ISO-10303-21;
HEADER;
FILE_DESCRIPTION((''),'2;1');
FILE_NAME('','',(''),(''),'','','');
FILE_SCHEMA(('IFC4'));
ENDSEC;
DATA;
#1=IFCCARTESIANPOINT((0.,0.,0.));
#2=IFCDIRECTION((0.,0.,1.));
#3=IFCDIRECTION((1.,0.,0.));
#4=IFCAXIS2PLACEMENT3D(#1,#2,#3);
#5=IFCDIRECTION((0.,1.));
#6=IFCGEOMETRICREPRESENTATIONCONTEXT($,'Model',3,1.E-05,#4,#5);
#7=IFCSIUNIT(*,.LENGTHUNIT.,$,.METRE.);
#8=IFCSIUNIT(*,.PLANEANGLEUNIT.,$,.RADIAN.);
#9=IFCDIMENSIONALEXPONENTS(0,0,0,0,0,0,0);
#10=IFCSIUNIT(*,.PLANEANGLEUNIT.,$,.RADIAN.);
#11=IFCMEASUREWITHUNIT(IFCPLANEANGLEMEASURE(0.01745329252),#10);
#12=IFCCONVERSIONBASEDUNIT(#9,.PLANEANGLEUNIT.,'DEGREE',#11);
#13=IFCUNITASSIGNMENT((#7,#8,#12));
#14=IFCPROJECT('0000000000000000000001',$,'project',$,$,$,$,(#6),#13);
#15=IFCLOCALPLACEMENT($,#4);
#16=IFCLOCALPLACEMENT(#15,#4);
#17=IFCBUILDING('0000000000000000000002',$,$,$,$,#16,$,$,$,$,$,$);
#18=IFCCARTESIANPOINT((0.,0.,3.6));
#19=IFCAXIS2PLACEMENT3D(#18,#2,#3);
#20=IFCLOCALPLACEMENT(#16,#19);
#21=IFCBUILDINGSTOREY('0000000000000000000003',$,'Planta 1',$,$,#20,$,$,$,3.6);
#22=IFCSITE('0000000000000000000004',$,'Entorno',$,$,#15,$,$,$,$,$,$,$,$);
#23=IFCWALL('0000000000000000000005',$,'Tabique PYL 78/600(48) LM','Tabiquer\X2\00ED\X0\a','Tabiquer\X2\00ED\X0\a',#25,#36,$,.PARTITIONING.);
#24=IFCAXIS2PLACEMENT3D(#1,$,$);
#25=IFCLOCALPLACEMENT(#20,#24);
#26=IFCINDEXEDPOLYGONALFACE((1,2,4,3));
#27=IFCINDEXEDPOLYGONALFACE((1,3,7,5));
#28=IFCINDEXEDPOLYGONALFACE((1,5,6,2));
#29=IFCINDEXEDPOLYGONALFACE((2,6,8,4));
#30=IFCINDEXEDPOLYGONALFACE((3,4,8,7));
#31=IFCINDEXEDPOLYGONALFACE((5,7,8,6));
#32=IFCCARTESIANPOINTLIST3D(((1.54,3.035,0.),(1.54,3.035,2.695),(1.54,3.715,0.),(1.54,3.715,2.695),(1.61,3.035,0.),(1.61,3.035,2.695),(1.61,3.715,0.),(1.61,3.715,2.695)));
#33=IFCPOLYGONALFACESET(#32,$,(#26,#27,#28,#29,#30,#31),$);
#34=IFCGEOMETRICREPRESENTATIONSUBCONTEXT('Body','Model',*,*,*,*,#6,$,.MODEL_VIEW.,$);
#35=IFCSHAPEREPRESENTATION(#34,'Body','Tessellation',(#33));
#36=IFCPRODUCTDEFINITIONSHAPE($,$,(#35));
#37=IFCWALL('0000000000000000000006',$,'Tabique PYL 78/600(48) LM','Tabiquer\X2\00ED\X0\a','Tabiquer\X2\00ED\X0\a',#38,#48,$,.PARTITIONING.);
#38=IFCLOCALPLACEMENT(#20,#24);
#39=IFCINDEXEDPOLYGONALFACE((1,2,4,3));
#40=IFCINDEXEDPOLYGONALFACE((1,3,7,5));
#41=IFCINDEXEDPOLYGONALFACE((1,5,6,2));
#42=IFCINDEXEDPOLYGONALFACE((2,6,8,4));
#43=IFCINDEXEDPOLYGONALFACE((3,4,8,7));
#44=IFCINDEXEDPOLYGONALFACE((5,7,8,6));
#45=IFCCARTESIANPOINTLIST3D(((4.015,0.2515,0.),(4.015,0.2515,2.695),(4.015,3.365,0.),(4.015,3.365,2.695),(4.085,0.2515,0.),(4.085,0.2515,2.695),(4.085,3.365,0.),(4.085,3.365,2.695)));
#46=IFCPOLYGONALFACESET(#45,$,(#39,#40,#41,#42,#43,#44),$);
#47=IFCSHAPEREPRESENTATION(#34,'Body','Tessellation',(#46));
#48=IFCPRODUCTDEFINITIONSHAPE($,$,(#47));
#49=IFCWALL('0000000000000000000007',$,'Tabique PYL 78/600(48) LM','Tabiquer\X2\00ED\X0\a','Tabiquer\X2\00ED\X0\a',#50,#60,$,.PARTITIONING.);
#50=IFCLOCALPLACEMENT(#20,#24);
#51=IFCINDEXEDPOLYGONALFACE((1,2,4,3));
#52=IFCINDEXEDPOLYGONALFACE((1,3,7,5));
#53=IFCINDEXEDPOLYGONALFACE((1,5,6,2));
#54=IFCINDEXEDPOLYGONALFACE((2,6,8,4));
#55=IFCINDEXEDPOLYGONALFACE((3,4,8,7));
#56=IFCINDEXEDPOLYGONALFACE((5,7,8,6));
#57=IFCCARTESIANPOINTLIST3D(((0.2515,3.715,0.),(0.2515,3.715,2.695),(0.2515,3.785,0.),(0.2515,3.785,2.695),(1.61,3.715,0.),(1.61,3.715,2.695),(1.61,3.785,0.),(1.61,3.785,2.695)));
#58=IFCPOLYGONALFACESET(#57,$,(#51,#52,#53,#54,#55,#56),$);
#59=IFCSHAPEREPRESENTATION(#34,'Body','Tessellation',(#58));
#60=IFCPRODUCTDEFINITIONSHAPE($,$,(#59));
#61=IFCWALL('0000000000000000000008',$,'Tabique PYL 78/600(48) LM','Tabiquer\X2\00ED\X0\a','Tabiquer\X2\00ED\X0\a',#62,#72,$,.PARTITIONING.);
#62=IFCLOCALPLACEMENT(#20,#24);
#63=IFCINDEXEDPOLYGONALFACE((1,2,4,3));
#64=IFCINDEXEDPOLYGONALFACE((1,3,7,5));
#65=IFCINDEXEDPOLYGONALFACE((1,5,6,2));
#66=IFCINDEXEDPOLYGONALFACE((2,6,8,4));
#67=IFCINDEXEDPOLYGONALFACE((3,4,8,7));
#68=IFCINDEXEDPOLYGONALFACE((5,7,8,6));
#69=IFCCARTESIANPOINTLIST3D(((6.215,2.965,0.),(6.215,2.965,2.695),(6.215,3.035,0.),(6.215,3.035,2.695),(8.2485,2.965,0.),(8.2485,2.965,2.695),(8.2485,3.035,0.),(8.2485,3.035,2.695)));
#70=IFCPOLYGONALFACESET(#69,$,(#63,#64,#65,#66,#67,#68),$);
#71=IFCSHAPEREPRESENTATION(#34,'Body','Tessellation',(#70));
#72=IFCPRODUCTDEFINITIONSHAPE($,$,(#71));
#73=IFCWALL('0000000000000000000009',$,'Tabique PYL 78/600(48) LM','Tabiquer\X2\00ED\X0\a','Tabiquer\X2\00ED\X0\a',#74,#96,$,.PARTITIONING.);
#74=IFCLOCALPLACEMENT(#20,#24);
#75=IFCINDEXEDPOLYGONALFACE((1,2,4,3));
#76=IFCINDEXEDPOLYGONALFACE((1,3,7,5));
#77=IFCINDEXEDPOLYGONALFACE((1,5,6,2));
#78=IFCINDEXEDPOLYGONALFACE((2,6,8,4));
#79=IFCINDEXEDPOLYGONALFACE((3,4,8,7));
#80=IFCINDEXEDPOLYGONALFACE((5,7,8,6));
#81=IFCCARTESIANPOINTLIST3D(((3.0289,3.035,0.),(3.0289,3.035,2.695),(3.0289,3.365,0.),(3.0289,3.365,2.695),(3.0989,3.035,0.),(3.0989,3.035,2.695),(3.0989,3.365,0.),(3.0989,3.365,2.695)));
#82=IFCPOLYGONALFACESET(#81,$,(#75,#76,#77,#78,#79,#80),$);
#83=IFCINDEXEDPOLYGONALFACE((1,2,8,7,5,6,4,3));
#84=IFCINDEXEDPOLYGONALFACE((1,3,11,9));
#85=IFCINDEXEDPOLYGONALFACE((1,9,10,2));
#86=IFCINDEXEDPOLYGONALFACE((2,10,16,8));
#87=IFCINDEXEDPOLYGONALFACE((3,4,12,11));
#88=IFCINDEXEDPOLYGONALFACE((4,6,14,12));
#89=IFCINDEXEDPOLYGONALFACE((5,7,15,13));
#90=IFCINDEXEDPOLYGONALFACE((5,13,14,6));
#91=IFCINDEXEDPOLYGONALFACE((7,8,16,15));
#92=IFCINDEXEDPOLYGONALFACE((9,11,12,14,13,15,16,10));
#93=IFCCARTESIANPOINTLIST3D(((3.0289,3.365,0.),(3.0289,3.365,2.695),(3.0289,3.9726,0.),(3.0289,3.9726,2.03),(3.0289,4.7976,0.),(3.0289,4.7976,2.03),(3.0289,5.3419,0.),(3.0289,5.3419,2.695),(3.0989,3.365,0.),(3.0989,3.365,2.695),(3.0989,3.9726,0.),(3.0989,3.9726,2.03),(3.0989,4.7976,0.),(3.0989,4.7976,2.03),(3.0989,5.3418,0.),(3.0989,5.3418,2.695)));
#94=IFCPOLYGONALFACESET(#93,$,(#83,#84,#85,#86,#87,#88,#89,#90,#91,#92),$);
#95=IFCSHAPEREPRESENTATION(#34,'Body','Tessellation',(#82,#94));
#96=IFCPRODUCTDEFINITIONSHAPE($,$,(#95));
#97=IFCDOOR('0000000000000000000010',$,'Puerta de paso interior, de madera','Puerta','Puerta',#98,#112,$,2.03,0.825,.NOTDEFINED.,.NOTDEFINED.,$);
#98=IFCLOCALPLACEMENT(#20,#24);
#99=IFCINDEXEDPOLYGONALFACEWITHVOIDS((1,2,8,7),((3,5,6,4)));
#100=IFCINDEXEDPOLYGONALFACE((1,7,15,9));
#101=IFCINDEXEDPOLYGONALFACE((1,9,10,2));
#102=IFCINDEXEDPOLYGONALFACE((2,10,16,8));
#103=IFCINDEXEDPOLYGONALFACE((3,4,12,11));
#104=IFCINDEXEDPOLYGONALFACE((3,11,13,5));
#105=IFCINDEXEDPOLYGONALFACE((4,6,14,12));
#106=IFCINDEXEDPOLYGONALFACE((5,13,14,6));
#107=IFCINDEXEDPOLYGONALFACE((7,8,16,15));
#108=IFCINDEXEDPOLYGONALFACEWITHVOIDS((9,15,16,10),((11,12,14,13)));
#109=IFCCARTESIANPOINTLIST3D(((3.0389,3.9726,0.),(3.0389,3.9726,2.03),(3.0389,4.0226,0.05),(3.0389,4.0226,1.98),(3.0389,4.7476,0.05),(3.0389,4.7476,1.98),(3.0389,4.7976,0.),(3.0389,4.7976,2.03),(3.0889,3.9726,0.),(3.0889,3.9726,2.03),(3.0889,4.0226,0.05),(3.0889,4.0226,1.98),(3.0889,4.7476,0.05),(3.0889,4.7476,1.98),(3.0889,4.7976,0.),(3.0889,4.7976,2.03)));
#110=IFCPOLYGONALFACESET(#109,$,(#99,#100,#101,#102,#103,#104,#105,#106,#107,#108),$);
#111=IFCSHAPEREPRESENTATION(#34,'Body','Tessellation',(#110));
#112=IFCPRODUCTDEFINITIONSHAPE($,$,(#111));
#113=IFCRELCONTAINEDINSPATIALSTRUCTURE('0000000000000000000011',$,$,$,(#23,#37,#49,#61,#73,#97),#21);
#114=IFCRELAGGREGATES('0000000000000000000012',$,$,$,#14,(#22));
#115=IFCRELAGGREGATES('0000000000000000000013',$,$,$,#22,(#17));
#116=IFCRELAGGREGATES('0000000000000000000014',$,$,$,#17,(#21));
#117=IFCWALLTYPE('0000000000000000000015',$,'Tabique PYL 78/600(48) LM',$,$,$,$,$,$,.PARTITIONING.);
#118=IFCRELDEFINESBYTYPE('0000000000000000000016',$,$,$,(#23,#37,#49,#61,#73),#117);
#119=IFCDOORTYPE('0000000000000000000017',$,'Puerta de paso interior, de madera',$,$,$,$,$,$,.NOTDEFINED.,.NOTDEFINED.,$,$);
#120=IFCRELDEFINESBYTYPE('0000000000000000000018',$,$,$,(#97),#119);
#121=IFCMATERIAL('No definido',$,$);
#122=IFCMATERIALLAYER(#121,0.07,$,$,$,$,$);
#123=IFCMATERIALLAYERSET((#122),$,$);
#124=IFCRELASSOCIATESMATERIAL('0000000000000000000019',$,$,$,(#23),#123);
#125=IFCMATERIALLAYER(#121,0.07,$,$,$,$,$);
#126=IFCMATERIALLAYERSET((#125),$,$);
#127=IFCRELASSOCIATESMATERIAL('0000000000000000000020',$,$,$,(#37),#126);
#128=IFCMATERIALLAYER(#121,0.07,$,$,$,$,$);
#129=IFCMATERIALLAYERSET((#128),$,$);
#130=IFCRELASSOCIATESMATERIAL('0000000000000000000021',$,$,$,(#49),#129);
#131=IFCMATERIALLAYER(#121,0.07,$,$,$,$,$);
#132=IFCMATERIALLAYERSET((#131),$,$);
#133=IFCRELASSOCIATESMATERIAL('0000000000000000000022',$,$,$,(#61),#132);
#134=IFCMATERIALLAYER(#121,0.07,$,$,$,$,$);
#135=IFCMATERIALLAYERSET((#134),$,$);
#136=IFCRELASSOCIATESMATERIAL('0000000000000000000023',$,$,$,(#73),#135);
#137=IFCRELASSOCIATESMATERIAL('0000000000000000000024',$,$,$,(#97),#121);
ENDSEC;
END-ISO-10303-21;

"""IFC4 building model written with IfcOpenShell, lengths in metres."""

from ifc_helpers import new_model, entity, si_unit, converted_unit, direction, frame, origin_with_axes, origin_2d_with_axis, place, context, subcontext, project, spatial, rectangle, hollow_rectangle, extrude, shape, material, layer, layer_set, layer_usage, type_object, element, fill, save


model = new_model("IFC4")

# Units and contexts
model_context = context("Model", 3, precision=1e-05, world=origin_with_axes(), true_north=direction((0.0, 1.0)))
body_context = subcontext(model_context, "Body", "Model", "MODEL_VIEW")
footprint_context = subcontext(model_context, "FootPrint", "Model", "MODEL_VIEW")
ifc_project = project(units=[si_unit("LENGTHUNIT", "METRE"), si_unit("PLANEANGLEUNIT", "RADIAN"), converted_unit("PLANEANGLEUNIT", "DEGREE", entity("IfcPlaneAngleMeasure", 0.01745329252), si_unit("PLANEANGLEUNIT", "RADIAN"), dimensions=[0, 0, 0, 0, 0, 0, 0])], contexts=[model_context])

# Site, building, storey
site_placement = place(None, origin_with_axes())
site = spatial("IfcSite", under=ifc_project, at=site_placement, Name="Entorno")
building_placement = place(site_placement, origin_with_axes())
building = spatial("IfcBuilding", under=site, at=building_placement)
storey_placement = place(building_placement, frame((0.0, 0.0, 3.6), z_axis=(0.0, 0.0, 1.0), x_axis=(1.0, 0.0, 0.0)))
storey = spatial("IfcBuildingStorey", under=building, at=storey_placement, Name="Planta 1", Elevation=3.6)

# Shared definitions
ifc_material = material(Name="No definido")

# Shared definitions
wall_type_1 = type_object("IfcWallType", Name="Tabique PYL 78/600(48) LM", PredefinedType="PARTITIONING")
door_type = type_object("IfcDoorType", Name="Puerta de paso interior, de madera", OperationType="NOTDEFINED", PredefinedType="NOTDEFINED")

# Walls
ifc_layer_1 = layer(ifc_material, 0.07)
ifc_layer_set_1 = layer_set([ifc_layer_1])
ifc_layer_usage_1 = layer_usage(ifc_layer_set_1, "AXIS2", "POSITIVE", -0.035)
wall_1_placement = place(storey_placement, frame((1.575, 3.75, 0.0), z_axis=(0.0, 0.0, 1.0), x_axis=(0.0, -1.0, 0.0)))
cartesian_point_1 = entity("IfcCartesianPoint", [-0.34, -1.3475])
cartesian_point_2 = entity("IfcCartesianPoint", [-0.34, -1.3475])
element("IfcWall", 1, at=wall_1_placement, inside=storey, type_object=wall_type_1, material=ifc_layer_usage_1, Name="Tabique PYL 78/600(48) LM", Description="Tabiquería", ObjectType="Tabiquería", PredefinedType="PARTITIONING", context=body_context, shape_type="SolidModel", body=[
    entity("IfcExtrudedAreaSolidTapered", entity("IfcArbitraryClosedProfileDef", "AREA", None, entity("IfcPolyline", [cartesian_point_1, entity("IfcCartesianPoint", [0.34, -1.3475]), entity("IfcCartesianPoint", [0.34, 1.3475]), entity("IfcCartesianPoint", [-0.34, 1.3475]), cartesian_point_1])), entity("IfcAxis2Placement3D", entity("IfcCartesianPoint", [0.375, 0.035, 1.3475]), entity("IfcDirection", [0.0, -1.0, 0.0]), entity("IfcDirection", [1.0, 0.0, 0.0])), entity("IfcDirection", [0.0, 0.0, 1.0]), 0.07, entity("IfcArbitraryClosedProfileDef", "AREA", None, entity("IfcPolyline", [cartesian_point_2, entity("IfcCartesianPoint", [0.34, -1.3475]), entity("IfcCartesianPoint", [0.34, 1.3475]), entity("IfcCartesianPoint", [-0.34, 1.3475]), cartesian_point_2]))),
])
ifc_layer_2 = layer(ifc_material, 0.07)
ifc_layer_set_2 = layer_set([ifc_layer_2])
ifc_layer_usage_2 = layer_usage(ifc_layer_set_2, "AXIS2", "POSITIVE", -0.035)
wall_2_placement = place(storey_placement, frame((4.05, 3.4, 0.0), z_axis=(0.0, 0.0, 1.0), x_axis=(0.0, -1.0, 0.0)))
cartesian_point_3 = entity("IfcCartesianPoint", [-1.5568, -1.3475])
cartesian_point_4 = entity("IfcCartesianPoint", [-1.5568, -1.3475])
element("IfcWall", 2, at=wall_2_placement, inside=storey, type_object=wall_type_1, material=ifc_layer_usage_2, Name="Tabique PYL 78/600(48) LM", Description="Tabiquería", ObjectType="Tabiquería", PredefinedType="PARTITIONING", context=body_context, shape_type="SolidModel", body=[
    entity("IfcExtrudedAreaSolidTapered", entity("IfcArbitraryClosedProfileDef", "AREA", None, entity("IfcPolyline", [cartesian_point_3, entity("IfcCartesianPoint", [1.5568, -1.3475]), entity("IfcCartesianPoint", [1.5568, 1.3475]), entity("IfcCartesianPoint", [-1.5568, 1.3475]), cartesian_point_3])), entity("IfcAxis2Placement3D", entity("IfcCartesianPoint", [1.5917, 0.035, 1.3475]), entity("IfcDirection", [0.0, -1.0, 0.0]), entity("IfcDirection", [1.0, 0.0, 0.0])), entity("IfcDirection", [0.0, 0.0, 1.0]), 0.07, entity("IfcArbitraryClosedProfileDef", "AREA", None, entity("IfcPolyline", [cartesian_point_4, entity("IfcCartesianPoint", [1.5568, -1.3475]), entity("IfcCartesianPoint", [1.5568, 1.3475]), entity("IfcCartesianPoint", [-1.5568, 1.3475]), cartesian_point_4]))),
])
ifc_layer_3 = layer(ifc_material, 0.07)
ifc_layer_set_3 = layer_set([ifc_layer_3])
ifc_layer_usage_3 = layer_usage(ifc_layer_set_3, "AXIS2", "POSITIVE", -0.035)
wall_3_placement = place(storey_placement, frame((1.575, 3.75, 0.0), z_axis=(0.0, 0.0, 1.0), x_axis=(-1.0, 0.0, 0.0)))
cartesian_point_5 = entity("IfcCartesianPoint", [-0.6793, -1.3475])
cartesian_point_6 = entity("IfcCartesianPoint", [-0.6793, -1.3475])
element("IfcWall", 3, at=wall_3_placement, inside=storey, type_object=wall_type_1, material=ifc_layer_usage_3, Name="Tabique PYL 78/600(48) LM", Description="Tabiquería", ObjectType="Tabiquería", PredefinedType="PARTITIONING", context=body_context, shape_type="SolidModel", body=[
    entity("IfcExtrudedAreaSolidTapered", entity("IfcArbitraryClosedProfileDef", "AREA", None, entity("IfcPolyline", [cartesian_point_5, entity("IfcCartesianPoint", [0.6793, -1.3475]), entity("IfcCartesianPoint", [0.6793, 1.3475]), entity("IfcCartesianPoint", [-0.6793, 1.3475]), cartesian_point_5])), entity("IfcAxis2Placement3D", entity("IfcCartesianPoint", [0.6442, 0.035, 1.3475]), entity("IfcDirection", [0.0, -1.0, 0.0]), entity("IfcDirection", [1.0, 0.0, 0.0])), entity("IfcDirection", [0.0, 0.0, 1.0]), 0.07, entity("IfcArbitraryClosedProfileDef", "AREA", None, entity("IfcPolyline", [cartesian_point_6, entity("IfcCartesianPoint", [0.6793, -1.3475]), entity("IfcCartesianPoint", [0.6793, 1.3475]), entity("IfcCartesianPoint", [-0.6793, 1.3475]), cartesian_point_6]))),
])
ifc_layer_4 = layer(ifc_material, 0.07)
ifc_layer_set_4 = layer_set([ifc_layer_4])
ifc_layer_usage_4 = layer_usage(ifc_layer_set_4, "AXIS2", "POSITIVE", -0.035)
wall_4_placement = place(storey_placement, frame((6.25, 3.0, 0.0), z_axis=(0.0, 0.0, 1.0), x_axis=(1.0, 0.0, 0.0)))
cartesian_point_7 = entity("IfcCartesianPoint", [-1.0168, -1.3475])
cartesian_point_8 = entity("IfcCartesianPoint", [-1.0168, -1.3475])
element("IfcWall", 4, at=wall_4_placement, inside=storey, type_object=wall_type_1, material=ifc_layer_usage_4, Name="Tabique PYL 78/600(48) LM", Description="Tabiquería", ObjectType="Tabiquería", PredefinedType="PARTITIONING", context=body_context, shape_type="SolidModel", body=[
    entity("IfcExtrudedAreaSolidTapered", entity("IfcArbitraryClosedProfileDef", "AREA", None, entity("IfcPolyline", [cartesian_point_7, entity("IfcCartesianPoint", [1.0168, -1.3475]), entity("IfcCartesianPoint", [1.0168, 1.3475]), entity("IfcCartesianPoint", [-1.0168, 1.3475]), cartesian_point_7])), entity("IfcAxis2Placement3D", entity("IfcCartesianPoint", [0.9818, 0.035, 1.3475]), entity("IfcDirection", [0.0, -1.0, 0.0]), entity("IfcDirection", [1.0, 0.0, 0.0])), entity("IfcDirection", [0.0, 0.0, 1.0]), 0.07, entity("IfcArbitraryClosedProfileDef", "AREA", None, entity("IfcPolyline", [cartesian_point_8, entity("IfcCartesianPoint", [1.0168, -1.3475]), entity("IfcCartesianPoint", [1.0168, 1.3475]), entity("IfcCartesianPoint", [-1.0168, 1.3475]), cartesian_point_8]))),
])

# Wall, opening, door
ifc_layer_5 = layer(ifc_material, 0.07)
ifc_layer_set_5 = layer_set([ifc_layer_5])
ifc_layer_usage_5 = layer_usage(ifc_layer_set_5, "AXIS2", "POSITIVE", -0.035)
wall_5_placement = place(storey_placement, frame((3.0639, 3.0, 0.0), z_axis=(0.0, 0.0, 1.0), x_axis=(0.0, 1.0, 0.0)))
cartesian_point_9 = entity("IfcCartesianPoint", [-0.165, -1.3475])
cartesian_point_10 = entity("IfcCartesianPoint", [-0.165, -1.3475])
cartesian_point_11 = entity("IfcCartesianPoint", [-0.9885, -1.3475])
cartesian_point_12 = entity("IfcCartesianPoint", [-0.9884, -1.3475])
wall_5 = element("IfcWall", 5, at=wall_5_placement, inside=storey, type_object=wall_type_1, material=ifc_layer_usage_5, Name="Tabique PYL 78/600(48) LM", Description="Tabiquería", ObjectType="Tabiquería", PredefinedType="PARTITIONING", context=body_context, shape_type="SolidModel", body=[
    entity("IfcExtrudedAreaSolidTapered", entity("IfcArbitraryClosedProfileDef", "AREA", None, entity("IfcPolyline", [cartesian_point_9, entity("IfcCartesianPoint", [0.165, -1.3475]), entity("IfcCartesianPoint", [0.165, 1.3475]), entity("IfcCartesianPoint", [-0.165, 1.3475]), cartesian_point_9])), entity("IfcAxis2Placement3D", entity("IfcCartesianPoint", [0.2, 0.035, 1.3475]), entity("IfcDirection", [0.0, -1.0, 0.0]), entity("IfcDirection", [1.0, 0.0, 0.0])), entity("IfcDirection", [0.0, 0.0, 1.0]), 0.07, entity("IfcArbitraryClosedProfileDef", "AREA", None, entity("IfcPolyline", [cartesian_point_10, entity("IfcCartesianPoint", [0.165, -1.3475]), entity("IfcCartesianPoint", [0.165, 1.3475]), entity("IfcCartesianPoint", [-0.165, 1.3475]), cartesian_point_10]))),
    entity("IfcExtrudedAreaSolidTapered", entity("IfcArbitraryClosedProfileDef", "AREA", None, entity("IfcPolyline", [cartesian_point_11, entity("IfcCartesianPoint", [0.9885, -1.3475]), entity("IfcCartesianPoint", [0.9885, 1.3475]), entity("IfcCartesianPoint", [-0.9885, 1.3475]), cartesian_point_11])), entity("IfcAxis2Placement3D", entity("IfcCartesianPoint", [1.3535, 0.035, 1.3475]), entity("IfcDirection", [0.0, -1.0, 0.0]), entity("IfcDirection", [1.0, 0.0, 0.0])), entity("IfcDirection", [-0.001121, 0.0, 0.999999]), 0.07, entity("IfcArbitraryClosedProfileDef", "AREA", None, entity("IfcPolyline", [cartesian_point_12, entity("IfcCartesianPoint", [0.9884, -1.3475]), entity("IfcCartesianPoint", [0.9884, 1.3475]), entity("IfcCartesianPoint", [-0.9884, 1.3475]), cartesian_point_12]))),
])
opening_1_placement = place(wall_5_placement, frame((1.3851, 0.0, 1.015), z_axis=(0.0, 0.0, 1.0), x_axis=(1.0, 0.0, 0.0)))
cartesian_point_13 = entity("IfcCartesianPoint", [-0.4125, -0.035])
opening_1 = element("IfcOpeningElement", 6, at=opening_1_placement, cuts=wall_5, ObjectType="No definido", PredefinedType="OPENING", shapes=[
    shape(body_context, "Body", "SweptSolid", [extrude(rectangle(XDim=2.03, YDim=0.825, at=origin_2d_with_axis()), frame((0.0, -0.035, 0.0), z_axis=(0.0, 1.0, 0.0), x_axis=(0.0, 0.0, 1.0)), (0.0, 0.0, 1.0), 0.07)]),
    shape(footprint_context, "FootPrint", "GeometricCurveSet", [entity("IfcGeometricCurveSet", [entity("IfcPolyline", [cartesian_point_13, entity("IfcCartesianPoint", [0.4125, -0.035]), entity("IfcCartesianPoint", [0.4125, 0.035]), entity("IfcCartesianPoint", [-0.4125, 0.035]), cartesian_point_13])])]),
])
door_1_placement = place(opening_1_placement, origin_with_axes())
door_1 = element("IfcDoor", 7, at=door_1_placement, inside=storey, type_object=door_type, material=ifc_material, Name="Puerta de paso interior, de madera", Description="Puerta", ObjectType="Puerta", OperationType="NOTDEFINED", OverallHeight=2.03, OverallWidth=0.825, PredefinedType="NOTDEFINED", context=body_context, shape_type="SweptSolid", body=[
    extrude(hollow_rectangle(XDim=0.825, YDim=2.03, WallThickness=0.05, InnerFilletRadius=0.0, OuterFilletRadius=0.0, at=origin_2d_with_axis()), frame((0.0, 0.025, 0.0), z_axis=(0.0, -1.0, 0.0), x_axis=(1.0, 0.0, 0.0)), (0.0, 0.0, 1.0), 0.05),
])
fill(opening_1, door_1)

save(model, "model.ifc")
